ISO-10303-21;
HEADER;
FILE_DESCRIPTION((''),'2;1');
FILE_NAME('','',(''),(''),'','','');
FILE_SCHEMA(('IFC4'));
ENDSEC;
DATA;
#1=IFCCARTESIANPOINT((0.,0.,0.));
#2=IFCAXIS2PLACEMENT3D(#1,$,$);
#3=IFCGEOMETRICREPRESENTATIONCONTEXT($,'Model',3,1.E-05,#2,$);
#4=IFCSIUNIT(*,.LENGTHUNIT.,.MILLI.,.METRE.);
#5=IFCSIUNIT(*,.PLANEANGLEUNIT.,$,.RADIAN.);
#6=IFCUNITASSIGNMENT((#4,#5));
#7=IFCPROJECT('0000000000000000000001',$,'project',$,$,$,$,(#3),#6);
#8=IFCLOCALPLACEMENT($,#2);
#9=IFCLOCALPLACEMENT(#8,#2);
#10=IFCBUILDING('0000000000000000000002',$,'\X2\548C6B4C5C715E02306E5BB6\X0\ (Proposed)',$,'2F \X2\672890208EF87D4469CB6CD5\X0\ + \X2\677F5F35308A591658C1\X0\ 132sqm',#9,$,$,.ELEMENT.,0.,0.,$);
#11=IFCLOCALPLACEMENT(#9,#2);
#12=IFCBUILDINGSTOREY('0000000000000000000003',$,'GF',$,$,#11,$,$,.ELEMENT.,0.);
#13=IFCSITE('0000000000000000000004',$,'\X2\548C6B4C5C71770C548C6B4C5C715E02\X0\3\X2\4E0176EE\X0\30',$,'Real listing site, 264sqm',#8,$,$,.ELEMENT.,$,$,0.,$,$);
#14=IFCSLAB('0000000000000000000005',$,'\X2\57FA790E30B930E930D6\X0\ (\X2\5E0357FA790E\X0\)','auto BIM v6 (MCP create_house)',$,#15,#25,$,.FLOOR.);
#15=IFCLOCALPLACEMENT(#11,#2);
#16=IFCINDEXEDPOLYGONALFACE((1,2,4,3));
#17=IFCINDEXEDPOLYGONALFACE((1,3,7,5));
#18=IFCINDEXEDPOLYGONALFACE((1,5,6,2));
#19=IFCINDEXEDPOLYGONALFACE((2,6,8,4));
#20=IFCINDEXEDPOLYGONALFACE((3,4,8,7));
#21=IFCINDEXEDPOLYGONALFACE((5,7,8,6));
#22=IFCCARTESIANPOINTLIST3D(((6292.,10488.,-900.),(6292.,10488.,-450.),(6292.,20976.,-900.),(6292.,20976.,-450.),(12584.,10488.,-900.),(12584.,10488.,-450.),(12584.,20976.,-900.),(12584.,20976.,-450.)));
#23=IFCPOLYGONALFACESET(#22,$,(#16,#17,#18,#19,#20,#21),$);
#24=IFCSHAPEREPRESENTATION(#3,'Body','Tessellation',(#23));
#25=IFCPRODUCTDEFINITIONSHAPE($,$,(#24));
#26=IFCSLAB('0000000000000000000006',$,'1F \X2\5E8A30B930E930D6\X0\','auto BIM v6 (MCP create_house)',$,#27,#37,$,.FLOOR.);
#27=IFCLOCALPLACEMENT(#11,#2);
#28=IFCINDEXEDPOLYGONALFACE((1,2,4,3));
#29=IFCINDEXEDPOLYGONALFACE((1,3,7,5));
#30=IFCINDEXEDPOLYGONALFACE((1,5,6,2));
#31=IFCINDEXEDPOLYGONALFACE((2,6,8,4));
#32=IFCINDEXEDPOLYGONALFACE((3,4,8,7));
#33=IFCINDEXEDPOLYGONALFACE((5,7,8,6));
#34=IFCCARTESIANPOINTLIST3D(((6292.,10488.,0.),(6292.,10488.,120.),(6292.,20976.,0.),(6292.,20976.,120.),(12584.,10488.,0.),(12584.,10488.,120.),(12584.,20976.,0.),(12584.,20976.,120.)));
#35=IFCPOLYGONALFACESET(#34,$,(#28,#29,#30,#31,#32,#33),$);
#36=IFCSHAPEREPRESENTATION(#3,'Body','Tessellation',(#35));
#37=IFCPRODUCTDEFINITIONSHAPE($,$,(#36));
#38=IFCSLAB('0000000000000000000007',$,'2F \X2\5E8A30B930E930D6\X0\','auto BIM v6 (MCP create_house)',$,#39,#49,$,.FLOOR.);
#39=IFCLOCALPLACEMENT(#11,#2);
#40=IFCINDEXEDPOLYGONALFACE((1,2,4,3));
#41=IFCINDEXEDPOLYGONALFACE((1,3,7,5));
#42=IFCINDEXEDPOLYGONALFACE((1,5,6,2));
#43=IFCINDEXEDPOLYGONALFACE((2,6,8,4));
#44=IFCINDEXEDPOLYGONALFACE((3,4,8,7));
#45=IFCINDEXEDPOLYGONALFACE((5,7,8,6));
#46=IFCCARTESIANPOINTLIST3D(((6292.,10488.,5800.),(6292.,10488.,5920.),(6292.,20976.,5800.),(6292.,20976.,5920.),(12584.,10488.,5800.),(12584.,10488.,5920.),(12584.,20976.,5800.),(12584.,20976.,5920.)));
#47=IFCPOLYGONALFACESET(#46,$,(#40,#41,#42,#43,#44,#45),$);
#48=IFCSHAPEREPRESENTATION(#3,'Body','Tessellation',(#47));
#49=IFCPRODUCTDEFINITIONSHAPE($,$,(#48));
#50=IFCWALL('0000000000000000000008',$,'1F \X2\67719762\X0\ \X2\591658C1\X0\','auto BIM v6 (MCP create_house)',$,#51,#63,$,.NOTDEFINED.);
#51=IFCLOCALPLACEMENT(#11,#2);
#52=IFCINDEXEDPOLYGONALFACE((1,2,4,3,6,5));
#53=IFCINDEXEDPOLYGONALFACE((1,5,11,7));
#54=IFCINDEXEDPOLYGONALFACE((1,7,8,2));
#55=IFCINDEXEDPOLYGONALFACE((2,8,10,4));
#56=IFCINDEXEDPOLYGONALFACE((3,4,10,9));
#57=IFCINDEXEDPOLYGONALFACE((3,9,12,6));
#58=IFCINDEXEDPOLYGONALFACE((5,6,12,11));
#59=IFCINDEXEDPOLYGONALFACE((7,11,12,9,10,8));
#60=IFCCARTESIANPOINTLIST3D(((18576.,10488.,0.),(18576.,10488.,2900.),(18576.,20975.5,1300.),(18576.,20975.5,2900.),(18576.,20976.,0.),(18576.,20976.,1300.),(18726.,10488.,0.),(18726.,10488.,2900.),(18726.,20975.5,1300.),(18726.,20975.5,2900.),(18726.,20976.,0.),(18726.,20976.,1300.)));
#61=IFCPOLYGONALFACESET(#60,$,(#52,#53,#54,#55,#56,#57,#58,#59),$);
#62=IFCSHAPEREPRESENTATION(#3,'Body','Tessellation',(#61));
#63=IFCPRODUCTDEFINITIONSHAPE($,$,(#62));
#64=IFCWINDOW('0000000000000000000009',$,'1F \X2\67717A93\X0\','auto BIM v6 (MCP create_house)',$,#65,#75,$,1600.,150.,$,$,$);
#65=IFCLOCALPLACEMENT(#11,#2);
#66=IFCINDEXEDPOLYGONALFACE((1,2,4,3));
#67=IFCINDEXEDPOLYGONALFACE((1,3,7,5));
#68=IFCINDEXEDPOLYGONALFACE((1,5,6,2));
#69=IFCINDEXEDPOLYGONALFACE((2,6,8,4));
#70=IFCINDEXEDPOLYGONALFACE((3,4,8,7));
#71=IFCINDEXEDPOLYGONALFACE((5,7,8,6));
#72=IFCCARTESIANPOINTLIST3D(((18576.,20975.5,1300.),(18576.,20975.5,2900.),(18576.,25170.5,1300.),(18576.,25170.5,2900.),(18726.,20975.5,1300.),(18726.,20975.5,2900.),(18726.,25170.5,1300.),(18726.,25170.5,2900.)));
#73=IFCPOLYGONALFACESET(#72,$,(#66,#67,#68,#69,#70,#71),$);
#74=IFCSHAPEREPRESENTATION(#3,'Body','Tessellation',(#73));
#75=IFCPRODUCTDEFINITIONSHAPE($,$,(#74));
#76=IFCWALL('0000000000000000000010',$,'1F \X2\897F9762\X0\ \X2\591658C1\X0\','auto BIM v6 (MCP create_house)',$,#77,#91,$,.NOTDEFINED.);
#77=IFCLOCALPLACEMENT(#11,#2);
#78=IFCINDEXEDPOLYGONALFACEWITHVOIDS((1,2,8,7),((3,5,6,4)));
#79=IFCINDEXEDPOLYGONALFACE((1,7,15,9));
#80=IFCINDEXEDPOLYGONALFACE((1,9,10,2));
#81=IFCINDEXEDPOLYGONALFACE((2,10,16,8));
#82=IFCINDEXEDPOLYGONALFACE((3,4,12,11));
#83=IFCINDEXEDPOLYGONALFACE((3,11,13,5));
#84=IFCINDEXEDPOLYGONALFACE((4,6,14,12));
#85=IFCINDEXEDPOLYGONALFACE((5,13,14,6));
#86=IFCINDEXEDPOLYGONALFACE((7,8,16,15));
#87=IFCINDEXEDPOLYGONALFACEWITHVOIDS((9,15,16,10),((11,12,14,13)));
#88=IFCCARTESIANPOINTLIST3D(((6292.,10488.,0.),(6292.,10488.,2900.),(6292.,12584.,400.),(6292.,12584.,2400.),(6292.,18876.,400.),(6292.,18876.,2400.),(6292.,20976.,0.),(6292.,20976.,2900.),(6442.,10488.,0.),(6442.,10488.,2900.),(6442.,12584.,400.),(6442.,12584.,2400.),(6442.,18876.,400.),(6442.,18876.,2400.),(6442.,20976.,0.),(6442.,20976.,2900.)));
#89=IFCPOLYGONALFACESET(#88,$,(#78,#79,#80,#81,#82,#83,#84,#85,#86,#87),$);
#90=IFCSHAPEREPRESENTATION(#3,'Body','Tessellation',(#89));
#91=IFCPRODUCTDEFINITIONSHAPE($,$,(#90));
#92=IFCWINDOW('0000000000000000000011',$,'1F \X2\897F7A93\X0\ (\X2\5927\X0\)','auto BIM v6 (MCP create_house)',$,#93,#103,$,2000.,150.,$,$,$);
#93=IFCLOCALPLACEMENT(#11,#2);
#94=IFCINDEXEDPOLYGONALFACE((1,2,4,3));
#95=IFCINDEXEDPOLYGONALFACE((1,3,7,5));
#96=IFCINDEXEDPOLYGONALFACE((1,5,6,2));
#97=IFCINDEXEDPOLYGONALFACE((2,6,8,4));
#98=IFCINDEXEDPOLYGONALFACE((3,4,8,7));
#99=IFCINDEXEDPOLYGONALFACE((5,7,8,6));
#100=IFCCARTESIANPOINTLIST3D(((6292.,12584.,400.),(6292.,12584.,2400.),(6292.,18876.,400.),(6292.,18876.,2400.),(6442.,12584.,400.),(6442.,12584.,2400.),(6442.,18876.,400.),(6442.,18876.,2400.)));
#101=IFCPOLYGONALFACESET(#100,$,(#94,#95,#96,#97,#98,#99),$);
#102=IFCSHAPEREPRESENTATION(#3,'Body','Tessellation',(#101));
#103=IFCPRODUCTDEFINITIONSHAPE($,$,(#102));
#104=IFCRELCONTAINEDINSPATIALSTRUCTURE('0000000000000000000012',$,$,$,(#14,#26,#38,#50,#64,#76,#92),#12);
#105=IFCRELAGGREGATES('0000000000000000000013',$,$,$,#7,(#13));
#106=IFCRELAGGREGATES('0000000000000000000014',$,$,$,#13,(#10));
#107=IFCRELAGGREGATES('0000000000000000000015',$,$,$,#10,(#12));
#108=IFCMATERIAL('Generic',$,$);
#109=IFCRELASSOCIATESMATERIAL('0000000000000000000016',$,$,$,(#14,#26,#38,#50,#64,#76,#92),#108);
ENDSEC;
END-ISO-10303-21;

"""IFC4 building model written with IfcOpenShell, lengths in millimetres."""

from ifc_helpers import new_model, si_unit, frame, frame_2d, origin, place, context, project, spatial, rectangle, extrude, material, element, fill, save


model = new_model("IFC4")

# Units and contexts
model_context = context("Model", 3, precision=1e-05, world=origin())
ifc_project = project(units=[si_unit("LENGTHUNIT", "METRE", prefix="MILLI"), si_unit("PLANEANGLEUNIT", "RADIAN")], contexts=[model_context])

# Site, building, storey
site_placement = place(None, origin())
site = spatial("IfcSite", under=ifc_project, at=site_placement, Name="和歌山県和歌山市3丁目30", ObjectType="Real listing site, 264sqm", CompositionType="ELEMENT", RefElevation=0.0)
building_placement = place(site_placement, origin())
building = spatial("IfcBuilding", under=site, at=building_placement, Name="和歌山市の家 (Proposed)", ObjectType="2F 木造軸組構法 + 板張り外壁 132sqm", CompositionType="ELEMENT", ElevationOfRefHeight=0.0, ElevationOfTerrain=0.0)
storey_placement = place(building_placement, origin())
storey = spatial("IfcBuildingStorey", under=building, at=storey_placement, Name="GF", CompositionType="ELEMENT", Elevation=0.0)

# Slabs
ifc_material = material(Name="Generic")
slab_1_placement = place(storey_placement, frame((3146.0, 5244.0, -450.0)))
element("IfcSlab", 1, at=slab_1_placement, inside=storey, material=ifc_material, Name="基礎スラブ (布基礎)", Description="auto BIM v6 (MCP create_house)", PredefinedType="FLOOR", context=model_context, shape_type="SweptSolid", body=[
    extrude(rectangle(XDim=6292.0, YDim=10488.0, at=frame_2d((3146.0, 5244.0))), frame((3146.0, 5244.0, -450.0)), (0.0, 0.0, 1.0), 450.0),
])
slab_2_placement = place(storey_placement, frame((3146.0, 5244.0, 0.0)))
element("IfcSlab", 2, at=slab_2_placement, inside=storey, material=ifc_material, Name="1F 床スラブ", Description="auto BIM v6 (MCP create_house)", PredefinedType="FLOOR", context=model_context, shape_type="SweptSolid", body=[
    extrude(rectangle(XDim=6292.0, YDim=10488.0, at=frame_2d((3146.0, 5244.0))), frame((3146.0, 5244.0, 0.0)), (0.0, 0.0, 1.0), 120.0),
])
slab_3_placement = place(storey_placement, frame((3146.0, 5244.0, 2900.0)))
element("IfcSlab", 3, at=slab_3_placement, inside=storey, material=ifc_material, Name="2F 床スラブ", Description="auto BIM v6 (MCP create_house)", PredefinedType="FLOOR", context=model_context, shape_type="SweptSolid", body=[
    extrude(rectangle(XDim=6292.0, YDim=10488.0, at=frame_2d((3146.0, 5244.0))), frame((3146.0, 5244.0, 2900.0)), (0.0, 0.0, 1.0), 120.0),
])

# Walls, openings, windows
wall_1_placement = place(storey_placement, frame((9288.0, 5244.0, 0.0)))
wall_1 = element("IfcWall", 4, at=wall_1_placement, inside=storey, material=ifc_material, Name="1F 東面 外壁", Description="auto BIM v6 (MCP create_house)", PredefinedType="NOTDEFINED", context=model_context, shape_type="SweptSolid", body=[
    extrude(rectangle(XDim=150.0, YDim=10488.0, at=frame_2d((75.0, 5244.0))), frame((9288.0, 5244.0, 0.0)), (0.0, 0.0, 1.0), 2900.0),
])
opening_1_placement = place(storey_placement, frame((9288.0, 10488.0, 650.0)))
opening_1 = element("IfcOpeningElement", 5, at=opening_1_placement, cuts=wall_1, PredefinedType="NOTDEFINED", context=model_context, shape_type="SweptSolid", body=[
    extrude(rectangle(XDim=150.0, YDim=4195.0, at=frame_2d((75.0, 2097.0))), frame((9288.0, 10488.0, 650.0)), (0.0, 0.0, 1.0), 1600.0),
])
window_1_placement = place(storey_placement, frame((9288.0, 10488.0, 650.0)))
window_1 = element("IfcWindow", 6, at=window_1_placement, inside=storey, material=ifc_material, Name="1F 東窓", Description="auto BIM v6 (MCP create_house)", OverallHeight=1600.0, OverallWidth=150.0, context=model_context, shape_type="SweptSolid", body=[
    extrude(rectangle(XDim=150.0, YDim=4195.0, at=frame_2d((75.0, 2097.0))), frame((9288.0, 10488.0, 650.0)), (0.0, 0.0, 1.0), 1600.0),
])
fill(opening_1, window_1)
wall_2_placement = place(storey_placement, frame((3146.0, 5244.0, 0.0)))
wall_2 = element("IfcWall", 7, at=wall_2_placement, inside=storey, material=ifc_material, Name="1F 西面 外壁", Description="auto BIM v6 (MCP create_house)", PredefinedType="NOTDEFINED", context=model_context, shape_type="SweptSolid", body=[
    extrude(rectangle(XDim=150.0, YDim=10488.0, at=frame_2d((75.0, 5244.0))), frame((3146.0, 5244.0, 0.0)), (0.0, 0.0, 1.0), 2900.0),
])
opening_2_placement = place(storey_placement, frame((3146.0, 6292.0, 200.0)))
opening_2 = element("IfcOpeningElement", 8, at=opening_2_placement, cuts=wall_2, PredefinedType="NOTDEFINED", context=model_context, shape_type="SweptSolid", body=[
    extrude(rectangle(XDim=150.0, YDim=6292.0, at=frame_2d((75.0, 3146.0))), frame((3146.0, 6292.0, 200.0)), (0.0, 0.0, 1.0), 2000.0),
])
window_2_placement = place(storey_placement, frame((3146.0, 6292.0, 200.0)))
window_2 = element("IfcWindow", 9, at=window_2_placement, inside=storey, material=ifc_material, Name="1F 西窓 (大)", Description="auto BIM v6 (MCP create_house)", OverallHeight=2000.0, OverallWidth=150.0, context=model_context, shape_type="SweptSolid", body=[
    extrude(rectangle(XDim=150.0, YDim=6292.0, at=frame_2d((75.0, 3146.0))), frame((3146.0, 6292.0, 200.0)), (0.0, 0.0, 1.0), 2000.0),
])
fill(opening_2, window_2)

save(model, "model.ifc")
